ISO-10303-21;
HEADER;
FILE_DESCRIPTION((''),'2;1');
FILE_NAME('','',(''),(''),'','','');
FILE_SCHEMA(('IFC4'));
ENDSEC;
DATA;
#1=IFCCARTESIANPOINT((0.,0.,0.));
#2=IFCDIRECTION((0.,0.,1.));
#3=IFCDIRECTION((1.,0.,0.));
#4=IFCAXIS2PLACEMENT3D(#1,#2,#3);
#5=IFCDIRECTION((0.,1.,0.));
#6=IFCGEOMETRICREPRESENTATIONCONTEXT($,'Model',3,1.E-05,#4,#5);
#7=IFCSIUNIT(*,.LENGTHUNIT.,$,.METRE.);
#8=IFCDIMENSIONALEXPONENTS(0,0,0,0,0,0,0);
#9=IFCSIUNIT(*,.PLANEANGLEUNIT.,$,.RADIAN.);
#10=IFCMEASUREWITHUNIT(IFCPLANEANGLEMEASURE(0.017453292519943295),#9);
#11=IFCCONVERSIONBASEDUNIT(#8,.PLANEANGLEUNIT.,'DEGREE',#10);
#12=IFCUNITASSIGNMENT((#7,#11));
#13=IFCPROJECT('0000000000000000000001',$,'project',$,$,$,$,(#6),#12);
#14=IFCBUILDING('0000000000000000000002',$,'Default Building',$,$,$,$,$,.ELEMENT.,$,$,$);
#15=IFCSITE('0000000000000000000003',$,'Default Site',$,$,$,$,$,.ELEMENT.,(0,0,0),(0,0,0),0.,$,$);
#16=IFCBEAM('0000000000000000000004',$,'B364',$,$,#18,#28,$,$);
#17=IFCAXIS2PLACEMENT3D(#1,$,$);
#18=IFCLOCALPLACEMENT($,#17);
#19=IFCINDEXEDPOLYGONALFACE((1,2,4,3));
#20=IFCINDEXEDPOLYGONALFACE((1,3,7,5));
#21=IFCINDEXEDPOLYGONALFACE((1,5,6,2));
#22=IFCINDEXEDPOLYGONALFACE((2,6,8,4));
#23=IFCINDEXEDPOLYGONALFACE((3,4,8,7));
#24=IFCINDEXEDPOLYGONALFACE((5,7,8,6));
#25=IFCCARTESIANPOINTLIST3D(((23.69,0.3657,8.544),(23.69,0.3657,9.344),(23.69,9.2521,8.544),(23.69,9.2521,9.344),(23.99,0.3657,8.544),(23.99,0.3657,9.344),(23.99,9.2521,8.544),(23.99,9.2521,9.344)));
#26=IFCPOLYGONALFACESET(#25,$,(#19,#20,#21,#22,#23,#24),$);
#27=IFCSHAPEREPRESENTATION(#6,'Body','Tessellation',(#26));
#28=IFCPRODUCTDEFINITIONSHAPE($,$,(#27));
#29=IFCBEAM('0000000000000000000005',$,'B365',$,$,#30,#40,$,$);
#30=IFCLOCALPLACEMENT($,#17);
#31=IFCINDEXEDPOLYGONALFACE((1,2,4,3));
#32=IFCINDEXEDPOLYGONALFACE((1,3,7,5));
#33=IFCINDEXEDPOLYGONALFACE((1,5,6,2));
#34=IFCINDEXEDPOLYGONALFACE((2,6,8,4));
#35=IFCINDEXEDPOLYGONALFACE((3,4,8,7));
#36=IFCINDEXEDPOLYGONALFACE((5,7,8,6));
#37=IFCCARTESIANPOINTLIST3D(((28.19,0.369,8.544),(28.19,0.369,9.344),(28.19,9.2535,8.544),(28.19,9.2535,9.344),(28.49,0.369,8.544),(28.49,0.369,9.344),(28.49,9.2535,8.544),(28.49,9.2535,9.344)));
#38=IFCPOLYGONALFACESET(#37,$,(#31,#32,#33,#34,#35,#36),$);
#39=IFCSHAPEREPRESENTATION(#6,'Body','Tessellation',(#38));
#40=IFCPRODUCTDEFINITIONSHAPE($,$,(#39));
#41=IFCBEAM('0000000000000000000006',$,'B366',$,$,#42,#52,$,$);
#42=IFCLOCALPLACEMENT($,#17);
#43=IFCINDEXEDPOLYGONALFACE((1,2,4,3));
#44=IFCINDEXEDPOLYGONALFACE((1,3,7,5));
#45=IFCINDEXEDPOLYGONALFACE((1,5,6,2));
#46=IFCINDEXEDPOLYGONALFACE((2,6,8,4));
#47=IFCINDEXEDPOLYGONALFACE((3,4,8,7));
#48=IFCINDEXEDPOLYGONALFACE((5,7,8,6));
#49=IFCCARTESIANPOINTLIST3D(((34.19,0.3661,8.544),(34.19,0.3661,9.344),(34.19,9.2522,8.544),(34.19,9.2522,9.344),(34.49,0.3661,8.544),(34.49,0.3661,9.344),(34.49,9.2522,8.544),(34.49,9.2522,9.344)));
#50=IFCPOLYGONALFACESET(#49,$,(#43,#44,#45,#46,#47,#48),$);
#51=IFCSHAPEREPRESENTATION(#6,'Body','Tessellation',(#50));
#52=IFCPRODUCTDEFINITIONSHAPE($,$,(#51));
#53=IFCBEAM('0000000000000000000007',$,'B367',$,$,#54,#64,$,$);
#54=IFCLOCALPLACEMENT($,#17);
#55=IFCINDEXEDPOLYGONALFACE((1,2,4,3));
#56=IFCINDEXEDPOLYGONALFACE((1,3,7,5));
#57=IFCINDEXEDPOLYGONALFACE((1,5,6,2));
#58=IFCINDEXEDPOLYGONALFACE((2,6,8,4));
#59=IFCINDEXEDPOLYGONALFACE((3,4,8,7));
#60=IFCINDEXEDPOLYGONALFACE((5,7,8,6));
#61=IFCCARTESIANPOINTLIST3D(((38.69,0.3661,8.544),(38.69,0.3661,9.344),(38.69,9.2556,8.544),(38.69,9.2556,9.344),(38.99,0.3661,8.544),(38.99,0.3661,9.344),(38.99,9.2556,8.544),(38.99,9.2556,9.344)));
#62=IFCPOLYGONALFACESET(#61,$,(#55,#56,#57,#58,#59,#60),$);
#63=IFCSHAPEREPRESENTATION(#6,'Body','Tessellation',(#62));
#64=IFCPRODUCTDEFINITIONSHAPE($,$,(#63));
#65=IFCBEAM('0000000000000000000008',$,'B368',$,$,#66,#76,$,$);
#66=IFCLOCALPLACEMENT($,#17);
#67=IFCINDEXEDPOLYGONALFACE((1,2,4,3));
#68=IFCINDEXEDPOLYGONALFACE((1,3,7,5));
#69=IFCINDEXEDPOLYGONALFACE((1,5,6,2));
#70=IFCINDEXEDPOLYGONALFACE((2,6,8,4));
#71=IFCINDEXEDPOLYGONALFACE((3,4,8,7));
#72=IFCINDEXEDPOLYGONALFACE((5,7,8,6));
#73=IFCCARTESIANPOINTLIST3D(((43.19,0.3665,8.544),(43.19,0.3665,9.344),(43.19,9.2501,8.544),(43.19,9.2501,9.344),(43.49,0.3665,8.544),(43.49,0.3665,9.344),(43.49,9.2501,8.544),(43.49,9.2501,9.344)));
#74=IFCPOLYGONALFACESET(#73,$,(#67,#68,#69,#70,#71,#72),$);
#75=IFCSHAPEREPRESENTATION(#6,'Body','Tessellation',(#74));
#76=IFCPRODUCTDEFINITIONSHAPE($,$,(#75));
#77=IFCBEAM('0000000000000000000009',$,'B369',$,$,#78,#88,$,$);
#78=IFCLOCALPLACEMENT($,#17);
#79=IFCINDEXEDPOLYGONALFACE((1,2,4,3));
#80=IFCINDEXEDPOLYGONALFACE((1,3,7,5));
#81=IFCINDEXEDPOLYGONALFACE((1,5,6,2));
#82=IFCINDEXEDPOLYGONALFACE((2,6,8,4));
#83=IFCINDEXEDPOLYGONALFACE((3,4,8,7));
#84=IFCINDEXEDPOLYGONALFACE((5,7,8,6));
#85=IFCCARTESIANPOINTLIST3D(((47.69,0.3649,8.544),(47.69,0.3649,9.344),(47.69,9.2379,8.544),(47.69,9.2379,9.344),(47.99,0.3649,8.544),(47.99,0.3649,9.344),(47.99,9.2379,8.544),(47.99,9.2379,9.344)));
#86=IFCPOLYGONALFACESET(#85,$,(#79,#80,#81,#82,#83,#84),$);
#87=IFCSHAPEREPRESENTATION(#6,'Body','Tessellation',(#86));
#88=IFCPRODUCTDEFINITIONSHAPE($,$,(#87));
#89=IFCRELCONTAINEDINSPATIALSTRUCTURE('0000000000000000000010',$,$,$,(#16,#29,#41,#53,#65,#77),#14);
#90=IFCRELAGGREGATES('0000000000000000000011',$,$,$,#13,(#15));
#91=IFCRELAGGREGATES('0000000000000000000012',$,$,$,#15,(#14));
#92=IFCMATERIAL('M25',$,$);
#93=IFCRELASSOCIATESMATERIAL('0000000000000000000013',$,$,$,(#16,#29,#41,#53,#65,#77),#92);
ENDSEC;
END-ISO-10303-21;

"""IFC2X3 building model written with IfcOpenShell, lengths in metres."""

from ifc_helpers import new_model, entity, si_unit, converted_unit, direction, frame, frame_2d, origin_with_axes, place, context, project, spatial, rectangle, extrude, material, element, save


model = new_model("IFC2X3")

# Units and contexts
model_context = context("Model", 3, precision=1e-05, world=origin_with_axes(), true_north=direction((0.0, 1.0, 0.0)))
ifc_project = project(units=[si_unit("LENGTHUNIT", "METRE"), converted_unit("PLANEANGLEUNIT", "DEGREE", entity("IfcPlaneAngleMeasure", 0.017453292519943295), si_unit("PLANEANGLEUNIT", "RADIAN"), dimensions=[0, 0, 0, 0, 0, 0, 0])], contexts=[model_context])

# Site, building
site = spatial("IfcSite", under=ifc_project, Name="Default Site", CompositionType="ELEMENT", RefLatitude=(0, 0, 0), RefLongitude=(0, 0, 0), RefElevation=0.0)
building = spatial("IfcBuilding", under=site, Name="Default Building", CompositionType="ELEMENT")

# Beams
ifc_material = material(Name="M25")
placement = place(None, origin_with_axes())
element("IfcBeam", 1, at=placement, inside=building, material=ifc_material, Name="B364", context=model_context, shape_type="SweptSolid", body=[
    extrude(rectangle(XDim=0.3, YDim=0.8, at=frame_2d((0.0, 0.0), x_axis=(0.0, 1.0, 0.0))), frame((23.84, 0.3657, 8.944), z_axis=(0.0, 1.0, 0.0), x_axis=(0.0, 0.0, -1.0)), (0.0, 0.0, 1.0), 8.8864),
])
element("IfcBeam", 2, at=placement, inside=building, material=ifc_material, Name="B365", context=model_context, shape_type="SweptSolid", body=[
    extrude(rectangle(XDim=0.3, YDim=0.8, at=frame_2d((0.0, 0.0), x_axis=(0.0, 1.0, 0.0))), frame((28.34, 0.369, 8.944), z_axis=(0.0, 1.0, 0.0), x_axis=(0.0, 0.0, -1.0)), (0.0, 0.0, 1.0), 8.8845),
])
element("IfcBeam", 3, at=placement, inside=building, material=ifc_material, Name="B366", context=model_context, shape_type="SweptSolid", body=[
    extrude(rectangle(XDim=0.3, YDim=0.8, at=frame_2d((0.0, 0.0), x_axis=(0.0, 1.0, 0.0))), frame((34.34, 0.3661, 8.944), z_axis=(0.0, 1.0, 0.0), x_axis=(0.0, 0.0, -1.0)), (0.0, 0.0, 1.0), 8.8861),
])
element("IfcBeam", 4, at=placement, inside=building, material=ifc_material, Name="B367", context=model_context, shape_type="SweptSolid", body=[
    extrude(rectangle(XDim=0.3, YDim=0.8, at=frame_2d((0.0, 0.0), x_axis=(0.0, 1.0, 0.0))), frame((38.84, 0.3661, 8.944), z_axis=(0.0, 1.0, 0.0), x_axis=(0.0, 0.0, -1.0)), (0.0, 0.0, 1.0), 8.8895),
])
element("IfcBeam", 5, at=placement, inside=building, material=ifc_material, Name="B368", context=model_context, shape_type="SweptSolid", body=[
    extrude(rectangle(XDim=0.3, YDim=0.8, at=frame_2d((0.0, 0.0), x_axis=(0.0, 1.0, 0.0))), frame((43.34, 0.3665, 8.944), z_axis=(0.0, 1.0, 0.0), x_axis=(0.0, 0.0, -1.0)), (0.0, 0.0, 1.0), 8.8836),
])
element("IfcBeam", 6, at=placement, inside=building, material=ifc_material, Name="B369", context=model_context, shape_type="SweptSolid", body=[
    extrude(rectangle(XDim=0.3, YDim=0.8, at=frame_2d((0.0, 0.0), x_axis=(0.0, 1.0, 0.0))), frame((47.84, 0.3649, 8.944), z_axis=(0.0, 1.0, 0.0), x_axis=(0.0, 0.0, -1.0)), (0.0, 0.0, 1.0), 8.873),
])

save(model, "model.ifc")
